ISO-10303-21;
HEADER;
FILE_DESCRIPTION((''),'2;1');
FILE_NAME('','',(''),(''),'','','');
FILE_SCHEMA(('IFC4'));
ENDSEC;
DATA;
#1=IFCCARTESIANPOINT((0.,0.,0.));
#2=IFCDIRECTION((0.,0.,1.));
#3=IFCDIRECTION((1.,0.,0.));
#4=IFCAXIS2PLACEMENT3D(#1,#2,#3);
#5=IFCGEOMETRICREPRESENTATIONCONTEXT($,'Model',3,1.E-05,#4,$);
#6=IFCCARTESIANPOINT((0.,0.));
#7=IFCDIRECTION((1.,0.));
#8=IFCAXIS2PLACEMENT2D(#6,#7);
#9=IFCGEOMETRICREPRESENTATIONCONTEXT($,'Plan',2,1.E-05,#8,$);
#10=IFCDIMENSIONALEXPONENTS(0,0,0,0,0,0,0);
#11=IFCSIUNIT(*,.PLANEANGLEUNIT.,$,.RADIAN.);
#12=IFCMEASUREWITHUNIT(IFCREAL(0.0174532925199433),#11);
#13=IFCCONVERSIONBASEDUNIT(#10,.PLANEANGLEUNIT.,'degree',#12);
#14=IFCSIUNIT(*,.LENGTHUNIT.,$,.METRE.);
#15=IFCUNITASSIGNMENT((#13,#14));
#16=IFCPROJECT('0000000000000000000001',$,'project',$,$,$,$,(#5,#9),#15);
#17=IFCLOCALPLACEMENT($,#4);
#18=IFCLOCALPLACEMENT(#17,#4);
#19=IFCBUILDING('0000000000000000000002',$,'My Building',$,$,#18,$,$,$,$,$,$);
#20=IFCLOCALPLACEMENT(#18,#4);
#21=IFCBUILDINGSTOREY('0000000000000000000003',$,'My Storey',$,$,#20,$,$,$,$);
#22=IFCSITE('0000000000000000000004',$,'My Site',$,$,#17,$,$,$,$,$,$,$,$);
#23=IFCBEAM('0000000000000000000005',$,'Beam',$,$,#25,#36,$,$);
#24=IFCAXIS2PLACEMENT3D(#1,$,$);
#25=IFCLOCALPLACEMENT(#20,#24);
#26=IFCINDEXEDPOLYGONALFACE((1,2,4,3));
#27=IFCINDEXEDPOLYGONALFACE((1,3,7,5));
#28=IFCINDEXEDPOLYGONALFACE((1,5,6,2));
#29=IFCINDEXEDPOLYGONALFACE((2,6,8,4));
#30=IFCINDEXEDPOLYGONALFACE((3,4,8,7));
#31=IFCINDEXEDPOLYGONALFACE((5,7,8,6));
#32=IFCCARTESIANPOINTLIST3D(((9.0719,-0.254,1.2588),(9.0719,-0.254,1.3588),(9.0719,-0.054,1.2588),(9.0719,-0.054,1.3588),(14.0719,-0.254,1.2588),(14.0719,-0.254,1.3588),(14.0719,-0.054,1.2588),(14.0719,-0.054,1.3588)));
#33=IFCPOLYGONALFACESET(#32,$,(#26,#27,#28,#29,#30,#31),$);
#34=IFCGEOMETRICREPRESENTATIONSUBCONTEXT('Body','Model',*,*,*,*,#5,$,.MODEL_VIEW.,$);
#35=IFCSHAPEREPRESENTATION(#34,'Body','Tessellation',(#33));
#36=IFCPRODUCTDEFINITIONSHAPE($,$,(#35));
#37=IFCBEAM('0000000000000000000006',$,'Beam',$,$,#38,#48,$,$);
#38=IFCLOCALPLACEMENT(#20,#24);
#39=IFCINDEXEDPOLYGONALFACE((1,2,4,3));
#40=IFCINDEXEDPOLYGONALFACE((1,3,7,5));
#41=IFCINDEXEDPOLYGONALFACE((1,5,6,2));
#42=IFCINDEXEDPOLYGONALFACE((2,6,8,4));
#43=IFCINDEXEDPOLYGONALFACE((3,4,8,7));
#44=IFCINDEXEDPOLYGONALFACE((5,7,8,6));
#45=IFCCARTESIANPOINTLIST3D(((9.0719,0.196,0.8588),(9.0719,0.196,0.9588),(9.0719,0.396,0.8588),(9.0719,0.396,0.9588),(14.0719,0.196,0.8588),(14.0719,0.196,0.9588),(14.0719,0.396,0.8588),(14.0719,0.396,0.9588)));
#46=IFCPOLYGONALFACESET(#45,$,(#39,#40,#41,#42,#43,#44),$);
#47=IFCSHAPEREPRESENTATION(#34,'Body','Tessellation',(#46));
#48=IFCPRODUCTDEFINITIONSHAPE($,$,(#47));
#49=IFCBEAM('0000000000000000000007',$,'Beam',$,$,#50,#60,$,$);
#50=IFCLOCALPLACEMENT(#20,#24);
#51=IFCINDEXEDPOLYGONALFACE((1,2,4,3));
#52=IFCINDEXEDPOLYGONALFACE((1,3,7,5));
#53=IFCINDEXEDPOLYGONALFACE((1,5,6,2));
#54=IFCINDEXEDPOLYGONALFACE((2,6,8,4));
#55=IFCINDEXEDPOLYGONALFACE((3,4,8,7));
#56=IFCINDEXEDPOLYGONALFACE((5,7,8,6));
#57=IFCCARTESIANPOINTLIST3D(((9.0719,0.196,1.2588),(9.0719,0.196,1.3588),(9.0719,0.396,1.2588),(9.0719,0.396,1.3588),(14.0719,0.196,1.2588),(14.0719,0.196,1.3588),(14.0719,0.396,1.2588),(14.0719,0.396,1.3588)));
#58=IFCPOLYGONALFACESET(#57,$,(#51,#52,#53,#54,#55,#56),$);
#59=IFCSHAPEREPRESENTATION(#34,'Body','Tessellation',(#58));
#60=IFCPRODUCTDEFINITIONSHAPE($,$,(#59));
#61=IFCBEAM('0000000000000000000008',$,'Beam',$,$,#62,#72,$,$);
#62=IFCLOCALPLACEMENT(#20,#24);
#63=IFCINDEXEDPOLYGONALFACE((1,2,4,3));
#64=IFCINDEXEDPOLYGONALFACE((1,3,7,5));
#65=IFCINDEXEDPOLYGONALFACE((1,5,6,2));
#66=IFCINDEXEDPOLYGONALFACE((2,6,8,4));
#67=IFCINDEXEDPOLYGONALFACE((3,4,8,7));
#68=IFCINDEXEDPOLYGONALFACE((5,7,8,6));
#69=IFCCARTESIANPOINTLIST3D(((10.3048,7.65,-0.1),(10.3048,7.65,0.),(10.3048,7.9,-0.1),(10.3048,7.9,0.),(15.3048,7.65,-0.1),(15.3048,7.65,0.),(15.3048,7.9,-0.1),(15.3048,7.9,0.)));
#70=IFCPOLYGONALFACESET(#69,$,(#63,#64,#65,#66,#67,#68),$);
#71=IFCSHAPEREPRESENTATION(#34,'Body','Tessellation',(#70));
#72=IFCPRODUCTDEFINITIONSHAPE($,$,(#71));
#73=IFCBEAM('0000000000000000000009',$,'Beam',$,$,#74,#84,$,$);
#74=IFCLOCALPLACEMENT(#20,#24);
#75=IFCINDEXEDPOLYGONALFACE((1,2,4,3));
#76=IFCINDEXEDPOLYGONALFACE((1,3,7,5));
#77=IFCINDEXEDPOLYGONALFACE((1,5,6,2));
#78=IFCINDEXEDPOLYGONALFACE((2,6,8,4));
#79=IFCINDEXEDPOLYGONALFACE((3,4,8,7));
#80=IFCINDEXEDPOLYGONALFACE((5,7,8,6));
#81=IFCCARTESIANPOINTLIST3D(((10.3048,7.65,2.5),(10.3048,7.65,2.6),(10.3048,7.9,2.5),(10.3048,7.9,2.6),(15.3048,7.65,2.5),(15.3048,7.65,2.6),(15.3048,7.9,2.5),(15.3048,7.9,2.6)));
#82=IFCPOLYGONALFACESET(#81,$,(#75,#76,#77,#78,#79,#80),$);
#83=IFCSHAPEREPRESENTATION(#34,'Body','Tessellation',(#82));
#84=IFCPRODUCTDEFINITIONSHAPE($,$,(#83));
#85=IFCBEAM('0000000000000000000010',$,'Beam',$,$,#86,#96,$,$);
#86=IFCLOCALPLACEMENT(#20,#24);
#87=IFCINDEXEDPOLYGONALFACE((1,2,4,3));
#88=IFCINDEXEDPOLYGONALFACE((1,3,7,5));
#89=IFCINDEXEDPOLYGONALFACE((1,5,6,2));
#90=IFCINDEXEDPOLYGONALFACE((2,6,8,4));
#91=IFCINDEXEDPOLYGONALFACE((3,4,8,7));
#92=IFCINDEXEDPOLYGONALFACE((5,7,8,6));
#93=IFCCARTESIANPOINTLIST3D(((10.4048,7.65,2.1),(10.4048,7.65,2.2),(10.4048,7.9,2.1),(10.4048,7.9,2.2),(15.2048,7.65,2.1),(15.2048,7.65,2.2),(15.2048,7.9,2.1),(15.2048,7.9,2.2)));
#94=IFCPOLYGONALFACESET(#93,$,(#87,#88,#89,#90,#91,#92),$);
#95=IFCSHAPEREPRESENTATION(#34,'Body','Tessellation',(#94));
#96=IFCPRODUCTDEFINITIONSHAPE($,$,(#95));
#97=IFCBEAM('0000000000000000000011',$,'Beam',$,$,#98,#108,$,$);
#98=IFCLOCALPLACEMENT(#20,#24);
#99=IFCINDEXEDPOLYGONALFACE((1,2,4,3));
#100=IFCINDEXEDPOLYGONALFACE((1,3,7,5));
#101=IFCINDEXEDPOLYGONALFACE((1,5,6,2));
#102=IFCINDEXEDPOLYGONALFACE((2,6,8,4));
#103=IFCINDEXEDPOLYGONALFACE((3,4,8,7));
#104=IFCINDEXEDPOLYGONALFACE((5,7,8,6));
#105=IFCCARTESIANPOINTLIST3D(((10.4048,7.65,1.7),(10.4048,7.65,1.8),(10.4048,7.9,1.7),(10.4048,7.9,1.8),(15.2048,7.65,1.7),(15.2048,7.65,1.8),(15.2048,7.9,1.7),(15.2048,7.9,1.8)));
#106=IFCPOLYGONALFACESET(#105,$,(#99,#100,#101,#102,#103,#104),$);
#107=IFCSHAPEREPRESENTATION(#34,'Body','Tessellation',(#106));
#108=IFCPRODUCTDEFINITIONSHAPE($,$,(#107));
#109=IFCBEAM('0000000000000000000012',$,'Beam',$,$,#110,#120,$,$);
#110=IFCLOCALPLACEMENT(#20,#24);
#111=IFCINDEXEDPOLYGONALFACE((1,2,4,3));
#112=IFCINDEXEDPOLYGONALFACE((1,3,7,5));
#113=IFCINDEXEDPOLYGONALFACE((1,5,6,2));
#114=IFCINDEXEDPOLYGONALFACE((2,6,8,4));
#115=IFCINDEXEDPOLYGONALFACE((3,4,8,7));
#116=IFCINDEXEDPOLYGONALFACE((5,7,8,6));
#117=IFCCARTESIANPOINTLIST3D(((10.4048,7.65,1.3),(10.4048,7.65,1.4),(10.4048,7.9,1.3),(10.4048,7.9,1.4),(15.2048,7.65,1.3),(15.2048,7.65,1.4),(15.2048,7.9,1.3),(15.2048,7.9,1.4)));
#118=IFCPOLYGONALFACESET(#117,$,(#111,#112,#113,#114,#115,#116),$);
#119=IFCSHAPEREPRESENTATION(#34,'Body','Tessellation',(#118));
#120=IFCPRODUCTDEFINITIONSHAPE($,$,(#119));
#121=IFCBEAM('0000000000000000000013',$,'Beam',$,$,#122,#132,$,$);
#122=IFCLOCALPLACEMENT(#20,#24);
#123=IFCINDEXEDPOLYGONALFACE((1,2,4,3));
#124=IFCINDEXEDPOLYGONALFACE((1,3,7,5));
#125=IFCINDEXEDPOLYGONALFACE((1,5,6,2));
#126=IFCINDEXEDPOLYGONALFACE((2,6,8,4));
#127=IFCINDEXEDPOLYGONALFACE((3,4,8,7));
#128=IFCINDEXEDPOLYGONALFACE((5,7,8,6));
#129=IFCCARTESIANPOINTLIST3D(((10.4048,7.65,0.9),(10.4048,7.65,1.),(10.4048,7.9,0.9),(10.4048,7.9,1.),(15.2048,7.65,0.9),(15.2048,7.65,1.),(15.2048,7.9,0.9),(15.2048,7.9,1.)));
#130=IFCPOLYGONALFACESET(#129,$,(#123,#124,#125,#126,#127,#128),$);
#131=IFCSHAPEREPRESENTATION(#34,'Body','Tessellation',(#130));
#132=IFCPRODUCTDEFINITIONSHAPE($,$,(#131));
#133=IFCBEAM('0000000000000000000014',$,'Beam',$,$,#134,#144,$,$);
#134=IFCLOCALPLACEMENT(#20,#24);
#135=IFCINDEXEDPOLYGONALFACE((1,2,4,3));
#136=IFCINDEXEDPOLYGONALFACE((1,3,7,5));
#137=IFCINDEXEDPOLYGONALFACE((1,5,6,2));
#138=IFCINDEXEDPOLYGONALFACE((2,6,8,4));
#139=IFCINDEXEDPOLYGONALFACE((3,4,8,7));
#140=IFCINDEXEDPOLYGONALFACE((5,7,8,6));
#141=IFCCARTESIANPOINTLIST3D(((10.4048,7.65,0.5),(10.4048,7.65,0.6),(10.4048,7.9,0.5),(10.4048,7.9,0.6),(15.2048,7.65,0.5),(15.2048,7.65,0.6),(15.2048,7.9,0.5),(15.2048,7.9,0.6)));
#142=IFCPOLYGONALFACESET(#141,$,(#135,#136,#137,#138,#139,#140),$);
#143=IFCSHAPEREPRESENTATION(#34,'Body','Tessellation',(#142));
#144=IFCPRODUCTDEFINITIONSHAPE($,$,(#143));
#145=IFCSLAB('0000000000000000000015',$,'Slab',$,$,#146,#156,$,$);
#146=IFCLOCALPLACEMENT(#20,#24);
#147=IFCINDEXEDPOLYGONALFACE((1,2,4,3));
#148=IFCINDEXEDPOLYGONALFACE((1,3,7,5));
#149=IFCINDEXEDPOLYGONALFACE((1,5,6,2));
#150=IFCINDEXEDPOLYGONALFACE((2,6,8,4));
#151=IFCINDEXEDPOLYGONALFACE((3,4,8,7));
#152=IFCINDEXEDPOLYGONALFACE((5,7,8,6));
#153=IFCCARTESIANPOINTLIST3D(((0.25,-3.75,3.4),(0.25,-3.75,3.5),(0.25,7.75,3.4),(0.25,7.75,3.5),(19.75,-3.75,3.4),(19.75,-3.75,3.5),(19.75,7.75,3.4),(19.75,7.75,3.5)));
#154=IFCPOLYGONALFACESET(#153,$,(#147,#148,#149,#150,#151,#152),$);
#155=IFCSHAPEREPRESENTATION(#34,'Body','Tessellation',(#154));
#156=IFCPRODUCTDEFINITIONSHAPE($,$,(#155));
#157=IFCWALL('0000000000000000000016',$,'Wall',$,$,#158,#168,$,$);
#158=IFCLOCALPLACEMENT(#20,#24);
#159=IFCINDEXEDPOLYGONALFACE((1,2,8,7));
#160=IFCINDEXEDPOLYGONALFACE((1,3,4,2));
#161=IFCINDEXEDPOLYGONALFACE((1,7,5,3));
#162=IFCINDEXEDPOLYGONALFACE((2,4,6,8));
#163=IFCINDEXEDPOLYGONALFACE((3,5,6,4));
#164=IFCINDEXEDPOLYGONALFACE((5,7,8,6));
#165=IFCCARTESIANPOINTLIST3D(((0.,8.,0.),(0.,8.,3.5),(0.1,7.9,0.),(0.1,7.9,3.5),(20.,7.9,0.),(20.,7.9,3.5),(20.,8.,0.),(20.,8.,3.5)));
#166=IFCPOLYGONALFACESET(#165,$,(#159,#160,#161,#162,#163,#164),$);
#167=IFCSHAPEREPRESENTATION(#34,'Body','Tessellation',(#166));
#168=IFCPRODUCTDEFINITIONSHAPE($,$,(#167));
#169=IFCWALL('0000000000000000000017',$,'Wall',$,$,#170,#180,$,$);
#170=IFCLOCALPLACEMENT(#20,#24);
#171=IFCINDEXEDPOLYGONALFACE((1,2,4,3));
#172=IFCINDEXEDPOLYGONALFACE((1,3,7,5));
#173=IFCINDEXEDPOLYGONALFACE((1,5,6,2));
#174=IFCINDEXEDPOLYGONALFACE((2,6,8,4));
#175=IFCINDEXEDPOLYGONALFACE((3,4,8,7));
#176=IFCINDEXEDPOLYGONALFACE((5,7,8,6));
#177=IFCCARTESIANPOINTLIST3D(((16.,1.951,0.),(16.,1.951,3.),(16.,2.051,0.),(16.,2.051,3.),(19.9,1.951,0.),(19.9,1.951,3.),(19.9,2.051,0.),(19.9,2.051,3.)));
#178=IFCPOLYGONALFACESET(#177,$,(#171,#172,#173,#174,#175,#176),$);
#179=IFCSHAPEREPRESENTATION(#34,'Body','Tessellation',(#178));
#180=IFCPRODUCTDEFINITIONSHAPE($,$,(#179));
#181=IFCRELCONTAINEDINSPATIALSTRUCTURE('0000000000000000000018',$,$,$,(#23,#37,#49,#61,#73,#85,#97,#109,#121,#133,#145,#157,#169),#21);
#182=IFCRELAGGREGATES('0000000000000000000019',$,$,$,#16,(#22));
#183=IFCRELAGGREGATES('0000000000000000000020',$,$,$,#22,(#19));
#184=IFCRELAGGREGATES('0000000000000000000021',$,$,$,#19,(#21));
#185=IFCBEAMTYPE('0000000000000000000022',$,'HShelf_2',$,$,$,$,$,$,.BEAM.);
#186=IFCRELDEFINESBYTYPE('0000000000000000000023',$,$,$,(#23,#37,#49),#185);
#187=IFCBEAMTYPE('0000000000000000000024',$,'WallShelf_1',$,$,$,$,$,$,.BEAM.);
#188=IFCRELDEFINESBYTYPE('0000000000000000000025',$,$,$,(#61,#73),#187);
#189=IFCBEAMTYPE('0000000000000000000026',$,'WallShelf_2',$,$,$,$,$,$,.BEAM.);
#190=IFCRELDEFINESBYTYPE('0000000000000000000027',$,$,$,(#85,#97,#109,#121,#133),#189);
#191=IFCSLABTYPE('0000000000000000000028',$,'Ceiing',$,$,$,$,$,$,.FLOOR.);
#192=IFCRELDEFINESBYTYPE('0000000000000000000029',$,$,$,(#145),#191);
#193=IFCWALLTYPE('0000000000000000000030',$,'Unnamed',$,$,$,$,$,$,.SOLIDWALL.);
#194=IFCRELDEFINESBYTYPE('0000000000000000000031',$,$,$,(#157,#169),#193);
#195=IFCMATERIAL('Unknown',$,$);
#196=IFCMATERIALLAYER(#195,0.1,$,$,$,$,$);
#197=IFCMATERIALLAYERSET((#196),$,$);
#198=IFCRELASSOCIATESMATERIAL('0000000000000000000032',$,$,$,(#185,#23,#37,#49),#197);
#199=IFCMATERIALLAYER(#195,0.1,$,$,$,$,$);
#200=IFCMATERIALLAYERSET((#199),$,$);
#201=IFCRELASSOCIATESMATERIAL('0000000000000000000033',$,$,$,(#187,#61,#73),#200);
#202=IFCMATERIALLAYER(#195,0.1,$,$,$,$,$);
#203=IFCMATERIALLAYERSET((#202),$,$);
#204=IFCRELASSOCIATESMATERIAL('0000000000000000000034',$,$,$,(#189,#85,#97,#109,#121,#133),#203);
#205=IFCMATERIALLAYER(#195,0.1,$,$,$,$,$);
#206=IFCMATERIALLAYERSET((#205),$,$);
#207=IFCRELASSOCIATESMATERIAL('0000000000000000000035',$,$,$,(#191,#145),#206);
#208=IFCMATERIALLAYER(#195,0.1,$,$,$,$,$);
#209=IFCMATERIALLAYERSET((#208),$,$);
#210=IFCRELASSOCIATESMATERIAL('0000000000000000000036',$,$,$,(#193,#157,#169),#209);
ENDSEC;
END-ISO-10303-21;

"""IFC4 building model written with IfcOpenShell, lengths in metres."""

from ifc_helpers import new_model, entity, si_unit, converted_unit, frame, origin_with_axes, origin_2d_with_axis, place, context, subcontext, project, spatial, line, indexed_curve, outline, extrude, material, layer, layer_set, layer_usage, type_object, element, save


model = new_model("IFC4")

# Units and contexts
model_context = context("Model", 3, precision=1e-05, world=origin_with_axes())
plan_context = context("Plan", 2, precision=1e-05, world=origin_2d_with_axis())
body_context_1 = subcontext(model_context, "Body", "Model", "MODEL_VIEW")
ifc_project = project(units=[converted_unit("PLANEANGLEUNIT", "degree", entity("IfcReal", 0.0174532925199433), si_unit("PLANEANGLEUNIT", "RADIAN"), dimensions=[0, 0, 0, 0, 0, 0, 0]), si_unit("LENGTHUNIT", "METRE")], contexts=[model_context, plan_context])

# Site, building, storey
site_placement = place(None, origin_with_axes())
site = spatial("IfcSite", under=ifc_project, at=site_placement, Name="My Site")
building_placement = place(site_placement, origin_with_axes())
building = spatial("IfcBuilding", under=site, at=building_placement, Name="My Building")
storey_placement = place(building_placement, origin_with_axes())
storey = spatial("IfcBuildingStorey", under=building, at=storey_placement, Name="My Storey")

# Shared definitions
ifc_material = material(Name="Unknown")

# Beams
ifc_layer_1 = layer(ifc_material, 0.1)
ifc_layer_set_1 = layer_set([ifc_layer_1])
beam_type_1 = type_object("IfcBeamType", Name="HShelf_2", PredefinedType="BEAM", material=ifc_layer_set_1)
ifc_layer_usage_1 = layer_usage(ifc_layer_set_1, "AXIS3", "POSITIVE", -0.1)
beam_1_placement = place(storey_placement, frame((9.0719, -0.054, 1.3588), z_axis=(0.0, 0.0, 1.0), x_axis=(1.0, 0.0, 0.0)))
element("IfcBeam", 1, at=beam_1_placement, inside=storey, type_object=beam_type_1, material=ifc_layer_usage_1, Name="Beam", context=body_context_1, shape_type="SweptSolid", body=[
    extrude(outline(indexed_curve([(0.0, 0.0), (0.0, -0.2), (5.0, -0.2), (5.0, 0.0), (0.0, 0.0)])), frame((0.0, 0.0, -0.1), z_axis=(0.0, 0.0, 1.0), x_axis=(1.0, 0.0, 0.0)), (0.0, 0.0, 1.0), 0.1),
])
ifc_layer_usage_2 = layer_usage(ifc_layer_set_1, "AXIS3", "POSITIVE", -0.1)
beam_2_placement = place(storey_placement, frame((9.0719, 0.396, 0.9588), z_axis=(0.0, 0.0, 1.0), x_axis=(1.0, 0.0, 0.0)))
element("IfcBeam", 2, at=beam_2_placement, inside=storey, type_object=beam_type_1, material=ifc_layer_usage_2, Name="Beam", context=body_context_1, shape_type="SweptSolid", body=[
    extrude(outline(indexed_curve([(0.0, 0.0), (0.0, -0.2), (5.0, -0.2), (5.0, 0.0), (0.0, 0.0)])), frame((0.0, 0.0, -0.1), z_axis=(0.0, 0.0, 1.0), x_axis=(1.0, 0.0, 0.0)), (0.0, 0.0, 1.0), 0.1),
])
ifc_layer_usage_3 = layer_usage(ifc_layer_set_1, "AXIS3", "POSITIVE", -0.1)
beam_3_placement = place(storey_placement, frame((9.0719, 0.396, 1.3588), z_axis=(0.0, 0.0, 1.0), x_axis=(1.0, 0.0, 0.0)))
element("IfcBeam", 3, at=beam_3_placement, inside=storey, type_object=beam_type_1, material=ifc_layer_usage_3, Name="Beam", context=body_context_1, shape_type="SweptSolid", body=[
    extrude(outline(indexed_curve([(0.0, 0.0), (0.0, -0.2), (5.0, -0.2), (5.0, 0.0), (0.0, 0.0)])), frame((0.0, 0.0, -0.1), z_axis=(0.0, 0.0, 1.0), x_axis=(1.0, 0.0, 0.0)), (0.0, 0.0, 1.0), 0.1),
])
ifc_layer_2 = layer(ifc_material, 0.1)
ifc_layer_set_2 = layer_set([ifc_layer_2])
ifc_layer_usage_4 = layer_usage(ifc_layer_set_2, "AXIS3", "POSITIVE", -0.1)
beam_type_2 = type_object("IfcBeamType", Name="WallShelf_1", PredefinedType="BEAM", material=ifc_layer_set_2)
beam_4_placement = place(storey_placement, frame((10.3048, 7.9, 0.0), z_axis=(0.0, 0.0, 1.0), x_axis=(1.0, 0.0, 0.0)))
element("IfcBeam", 4, at=beam_4_placement, inside=storey, type_object=beam_type_2, material=ifc_layer_usage_4, Name="Beam", context=body_context_1, shape_type="SweptSolid", body=[
    extrude(outline(indexed_curve([(0.0, 0.0), (5.0, 0.0), (5.0, -0.25), (0.0, -0.25), (0.0, 0.0), (0.0, 0.0)])), frame((0.0, 0.0, -0.1), z_axis=(0.0, 0.0, 1.0), x_axis=(1.0, 0.0, 0.0)), (0.0, 0.0, 1.0), 0.1),
])
ifc_layer_usage_5 = layer_usage(ifc_layer_set_2, "AXIS3", "POSITIVE", -0.1)
beam_5_placement = place(storey_placement, frame((10.3048, 7.9, 2.6), z_axis=(0.0, 0.0, 1.0), x_axis=(1.0, 0.0, 0.0)))
element("IfcBeam", 5, at=beam_5_placement, inside=storey, type_object=beam_type_2, material=ifc_layer_usage_5, Name="Beam", context=body_context_1, shape_type="SweptSolid", body=[
    extrude(outline(indexed_curve([(0.0, 0.0), (5.0, 0.0), (5.0, -0.25), (0.0, -0.25), (0.0, 0.0), (0.0, 0.0)])), frame((0.0, 0.0, -0.1), z_axis=(0.0, 0.0, 1.0), x_axis=(1.0, 0.0, 0.0)), (0.0, 0.0, 1.0), 0.1),
])
ifc_layer_3 = layer(ifc_material, 0.1)
ifc_layer_set_3 = layer_set([ifc_layer_3])
ifc_layer_usage_6 = layer_usage(ifc_layer_set_3, "AXIS3", "POSITIVE", -0.1)
beam_type_3 = type_object("IfcBeamType", Name="WallShelf_2", PredefinedType="BEAM", material=ifc_layer_set_3)
beam_6_placement = place(storey_placement, frame((15.2048, 7.9, 2.2), z_axis=(0.0, 0.0, 1.0), x_axis=(1.0, 0.0, 0.0)))
element("IfcBeam", 6, at=beam_6_placement, inside=storey, type_object=beam_type_3, material=ifc_layer_usage_6, Name="Beam", context=body_context_1, shape_type="SweptSolid", body=[
    extrude(outline(indexed_curve([(0.0, 0.0), (-4.8, 0.0), (-4.8, -0.25), (0.0, -0.25), (0.0, 0.0), (0.0, 0.0)])), frame((0.0, 0.0, -0.1), z_axis=(0.0, 0.0, 1.0), x_axis=(1.0, 0.0, 0.0)), (0.0, 0.0, 1.0), 0.1),
])
ifc_layer_usage_7 = layer_usage(ifc_layer_set_3, "AXIS3", "POSITIVE", -0.1)
beam_7_placement = place(storey_placement, frame((15.2048, 7.9, 1.8), z_axis=(0.0, 0.0, 1.0), x_axis=(1.0, 0.0, 0.0)))
element("IfcBeam", 7, at=beam_7_placement, inside=storey, type_object=beam_type_3, material=ifc_layer_usage_7, Name="Beam", context=body_context_1, shape_type="SweptSolid", body=[
    extrude(outline(indexed_curve([(0.0, 0.0), (-4.8, 0.0), (-4.8, -0.25), (0.0, -0.25), (0.0, 0.0), (0.0, 0.0)])), frame((0.0, 0.0, -0.1), z_axis=(0.0, 0.0, 1.0), x_axis=(1.0, 0.0, 0.0)), (0.0, 0.0, 1.0), 0.1),
])
ifc_layer_usage_8 = layer_usage(ifc_layer_set_3, "AXIS3", "POSITIVE", -0.1)
beam_8_placement = place(storey_placement, frame((15.2048, 7.9, 1.4), z_axis=(0.0, 0.0, 1.0), x_axis=(1.0, 0.0, 0.0)))
element("IfcBeam", 8, at=beam_8_placement, inside=storey, type_object=beam_type_3, material=ifc_layer_usage_8, Name="Beam", context=body_context_1, shape_type="SweptSolid", body=[
    extrude(outline(indexed_curve([(0.0, 0.0), (-4.8, 0.0), (-4.8, -0.25), (0.0, -0.25), (0.0, 0.0), (0.0, 0.0)])), frame((0.0, 0.0, -0.1), z_axis=(0.0, 0.0, 1.0), x_axis=(1.0, 0.0, 0.0)), (0.0, 0.0, 1.0), 0.1),
])
ifc_layer_usage_9 = layer_usage(ifc_layer_set_3, "AXIS3", "POSITIVE", -0.1)
beam_9_placement = place(storey_placement, frame((15.2048, 7.9, 1.0), z_axis=(0.0, 0.0, 1.0), x_axis=(1.0, 0.0, 0.0)))
element("IfcBeam", 9, at=beam_9_placement, inside=storey, type_object=beam_type_3, material=ifc_layer_usage_9, Name="Beam", context=body_context_1, shape_type="SweptSolid", body=[
    extrude(outline(indexed_curve([(0.0, 0.0), (-4.8, 0.0), (-4.8, -0.25), (0.0, -0.25), (0.0, 0.0), (0.0, 0.0)])), frame((0.0, 0.0, -0.1), z_axis=(0.0, 0.0, 1.0), x_axis=(1.0, 0.0, 0.0)), (0.0, 0.0, 1.0), 0.1),
])
ifc_layer_usage_10 = layer_usage(ifc_layer_set_3, "AXIS3", "POSITIVE", -0.1)
beam_10_placement = place(storey_placement, frame((15.2048, 7.9, 0.6), z_axis=(0.0, 0.0, 1.0), x_axis=(1.0, 0.0, 0.0)))
element("IfcBeam", 10, at=beam_10_placement, inside=storey, type_object=beam_type_3, material=ifc_layer_usage_10, Name="Beam", context=body_context_1, shape_type="SweptSolid", body=[
    extrude(outline(indexed_curve([(0.0, 0.0), (-4.8, 0.0), (-4.8, -0.25), (0.0, -0.25), (0.0, 0.0), (0.0, 0.0)])), frame((0.0, 0.0, -0.1), z_axis=(0.0, 0.0, 1.0), x_axis=(1.0, 0.0, 0.0)), (0.0, 0.0, 1.0), 0.1),
])

# Slab
ifc_layer_4 = layer(ifc_material, 0.1)
ifc_layer_set_4 = layer_set([ifc_layer_4])
ifc_layer_usage_11 = layer_usage(ifc_layer_set_4, "AXIS3", "POSITIVE", -0.1)
slab_type = type_object("IfcSlabType", Name="Ceiing", PredefinedType="FLOOR", material=ifc_layer_set_4)
slab_placement = place(storey_placement, frame((19.75, 7.75, 3.5), z_axis=(0.0, 0.0, 1.0), x_axis=(1.0, 0.0, 0.0)))
element("IfcSlab", 11, at=slab_placement, inside=storey, type_object=slab_type, material=ifc_layer_usage_11, Name="Slab", context=body_context_1, shape_type="SweptSolid", body=[
    extrude(outline(indexed_curve([(0.0, 0.0), (0.0, -11.5), (-19.5, -11.5), (-19.5, 0.0), (0.0, 0.0), (0.0, 0.0)])), frame((0.0, 0.0, -0.1), z_axis=(0.0, 0.0, 1.0), x_axis=(1.0, 0.0, 0.0)), (0.0, 0.0, 1.0), 0.1),
])

# Walls
ifc_layer_5 = layer(ifc_material, 0.1)
ifc_layer_set_5 = layer_set([ifc_layer_5])
ifc_layer_usage_12 = layer_usage(ifc_layer_set_5, "AXIS2", "POSITIVE", 0.0)
wall_type = type_object("IfcWallType", Name="Unnamed", PredefinedType="SOLIDWALL", material=ifc_layer_set_5)
wall_1_placement = place(storey_placement, frame((20.0, 8.0, 0.0), z_axis=(0.0, 0.0, 1.0), x_axis=(-1.0, 0.0, 0.0)))
element("IfcWall", 12, at=wall_1_placement, inside=storey, type_object=wall_type, material=ifc_layer_usage_12, Name="Wall", context=body_context_1, shape_type="SweptSolid", body=[
    extrude(outline(indexed_curve([(0.0, 0.0), (0.0, 0.1), (19.9, 0.1), (20.0, 0.0)], segments=[line(1, 2, 3, 4, 1)])), origin_with_axes(), (0.0, 0.0, 1.0), 3.5),
])
ifc_layer_usage_13 = layer_usage(ifc_layer_set_5, "AXIS2", "POSITIVE", 0.0)
wall_2_placement = place(storey_placement, frame((16.0, 1.951, 0.0), z_axis=(0.0, 0.0, 1.0), x_axis=(1.0, 0.0, 0.0)))
element("IfcWall", 13, at=wall_2_placement, inside=storey, type_object=wall_type, material=ifc_layer_usage_13, Name="Wall", context=body_context_1, shape_type="SweptSolid", body=[
    extrude(outline(indexed_curve([(0.0, 0.0), (0.0, 0.1), (3.9, 0.1), (3.9, 0.0)], segments=[line(1, 2, 3, 4, 1)])), origin_with_axes(), (0.0, 0.0, 1.0), 3.0),
])

save(model, "model.ifc")
